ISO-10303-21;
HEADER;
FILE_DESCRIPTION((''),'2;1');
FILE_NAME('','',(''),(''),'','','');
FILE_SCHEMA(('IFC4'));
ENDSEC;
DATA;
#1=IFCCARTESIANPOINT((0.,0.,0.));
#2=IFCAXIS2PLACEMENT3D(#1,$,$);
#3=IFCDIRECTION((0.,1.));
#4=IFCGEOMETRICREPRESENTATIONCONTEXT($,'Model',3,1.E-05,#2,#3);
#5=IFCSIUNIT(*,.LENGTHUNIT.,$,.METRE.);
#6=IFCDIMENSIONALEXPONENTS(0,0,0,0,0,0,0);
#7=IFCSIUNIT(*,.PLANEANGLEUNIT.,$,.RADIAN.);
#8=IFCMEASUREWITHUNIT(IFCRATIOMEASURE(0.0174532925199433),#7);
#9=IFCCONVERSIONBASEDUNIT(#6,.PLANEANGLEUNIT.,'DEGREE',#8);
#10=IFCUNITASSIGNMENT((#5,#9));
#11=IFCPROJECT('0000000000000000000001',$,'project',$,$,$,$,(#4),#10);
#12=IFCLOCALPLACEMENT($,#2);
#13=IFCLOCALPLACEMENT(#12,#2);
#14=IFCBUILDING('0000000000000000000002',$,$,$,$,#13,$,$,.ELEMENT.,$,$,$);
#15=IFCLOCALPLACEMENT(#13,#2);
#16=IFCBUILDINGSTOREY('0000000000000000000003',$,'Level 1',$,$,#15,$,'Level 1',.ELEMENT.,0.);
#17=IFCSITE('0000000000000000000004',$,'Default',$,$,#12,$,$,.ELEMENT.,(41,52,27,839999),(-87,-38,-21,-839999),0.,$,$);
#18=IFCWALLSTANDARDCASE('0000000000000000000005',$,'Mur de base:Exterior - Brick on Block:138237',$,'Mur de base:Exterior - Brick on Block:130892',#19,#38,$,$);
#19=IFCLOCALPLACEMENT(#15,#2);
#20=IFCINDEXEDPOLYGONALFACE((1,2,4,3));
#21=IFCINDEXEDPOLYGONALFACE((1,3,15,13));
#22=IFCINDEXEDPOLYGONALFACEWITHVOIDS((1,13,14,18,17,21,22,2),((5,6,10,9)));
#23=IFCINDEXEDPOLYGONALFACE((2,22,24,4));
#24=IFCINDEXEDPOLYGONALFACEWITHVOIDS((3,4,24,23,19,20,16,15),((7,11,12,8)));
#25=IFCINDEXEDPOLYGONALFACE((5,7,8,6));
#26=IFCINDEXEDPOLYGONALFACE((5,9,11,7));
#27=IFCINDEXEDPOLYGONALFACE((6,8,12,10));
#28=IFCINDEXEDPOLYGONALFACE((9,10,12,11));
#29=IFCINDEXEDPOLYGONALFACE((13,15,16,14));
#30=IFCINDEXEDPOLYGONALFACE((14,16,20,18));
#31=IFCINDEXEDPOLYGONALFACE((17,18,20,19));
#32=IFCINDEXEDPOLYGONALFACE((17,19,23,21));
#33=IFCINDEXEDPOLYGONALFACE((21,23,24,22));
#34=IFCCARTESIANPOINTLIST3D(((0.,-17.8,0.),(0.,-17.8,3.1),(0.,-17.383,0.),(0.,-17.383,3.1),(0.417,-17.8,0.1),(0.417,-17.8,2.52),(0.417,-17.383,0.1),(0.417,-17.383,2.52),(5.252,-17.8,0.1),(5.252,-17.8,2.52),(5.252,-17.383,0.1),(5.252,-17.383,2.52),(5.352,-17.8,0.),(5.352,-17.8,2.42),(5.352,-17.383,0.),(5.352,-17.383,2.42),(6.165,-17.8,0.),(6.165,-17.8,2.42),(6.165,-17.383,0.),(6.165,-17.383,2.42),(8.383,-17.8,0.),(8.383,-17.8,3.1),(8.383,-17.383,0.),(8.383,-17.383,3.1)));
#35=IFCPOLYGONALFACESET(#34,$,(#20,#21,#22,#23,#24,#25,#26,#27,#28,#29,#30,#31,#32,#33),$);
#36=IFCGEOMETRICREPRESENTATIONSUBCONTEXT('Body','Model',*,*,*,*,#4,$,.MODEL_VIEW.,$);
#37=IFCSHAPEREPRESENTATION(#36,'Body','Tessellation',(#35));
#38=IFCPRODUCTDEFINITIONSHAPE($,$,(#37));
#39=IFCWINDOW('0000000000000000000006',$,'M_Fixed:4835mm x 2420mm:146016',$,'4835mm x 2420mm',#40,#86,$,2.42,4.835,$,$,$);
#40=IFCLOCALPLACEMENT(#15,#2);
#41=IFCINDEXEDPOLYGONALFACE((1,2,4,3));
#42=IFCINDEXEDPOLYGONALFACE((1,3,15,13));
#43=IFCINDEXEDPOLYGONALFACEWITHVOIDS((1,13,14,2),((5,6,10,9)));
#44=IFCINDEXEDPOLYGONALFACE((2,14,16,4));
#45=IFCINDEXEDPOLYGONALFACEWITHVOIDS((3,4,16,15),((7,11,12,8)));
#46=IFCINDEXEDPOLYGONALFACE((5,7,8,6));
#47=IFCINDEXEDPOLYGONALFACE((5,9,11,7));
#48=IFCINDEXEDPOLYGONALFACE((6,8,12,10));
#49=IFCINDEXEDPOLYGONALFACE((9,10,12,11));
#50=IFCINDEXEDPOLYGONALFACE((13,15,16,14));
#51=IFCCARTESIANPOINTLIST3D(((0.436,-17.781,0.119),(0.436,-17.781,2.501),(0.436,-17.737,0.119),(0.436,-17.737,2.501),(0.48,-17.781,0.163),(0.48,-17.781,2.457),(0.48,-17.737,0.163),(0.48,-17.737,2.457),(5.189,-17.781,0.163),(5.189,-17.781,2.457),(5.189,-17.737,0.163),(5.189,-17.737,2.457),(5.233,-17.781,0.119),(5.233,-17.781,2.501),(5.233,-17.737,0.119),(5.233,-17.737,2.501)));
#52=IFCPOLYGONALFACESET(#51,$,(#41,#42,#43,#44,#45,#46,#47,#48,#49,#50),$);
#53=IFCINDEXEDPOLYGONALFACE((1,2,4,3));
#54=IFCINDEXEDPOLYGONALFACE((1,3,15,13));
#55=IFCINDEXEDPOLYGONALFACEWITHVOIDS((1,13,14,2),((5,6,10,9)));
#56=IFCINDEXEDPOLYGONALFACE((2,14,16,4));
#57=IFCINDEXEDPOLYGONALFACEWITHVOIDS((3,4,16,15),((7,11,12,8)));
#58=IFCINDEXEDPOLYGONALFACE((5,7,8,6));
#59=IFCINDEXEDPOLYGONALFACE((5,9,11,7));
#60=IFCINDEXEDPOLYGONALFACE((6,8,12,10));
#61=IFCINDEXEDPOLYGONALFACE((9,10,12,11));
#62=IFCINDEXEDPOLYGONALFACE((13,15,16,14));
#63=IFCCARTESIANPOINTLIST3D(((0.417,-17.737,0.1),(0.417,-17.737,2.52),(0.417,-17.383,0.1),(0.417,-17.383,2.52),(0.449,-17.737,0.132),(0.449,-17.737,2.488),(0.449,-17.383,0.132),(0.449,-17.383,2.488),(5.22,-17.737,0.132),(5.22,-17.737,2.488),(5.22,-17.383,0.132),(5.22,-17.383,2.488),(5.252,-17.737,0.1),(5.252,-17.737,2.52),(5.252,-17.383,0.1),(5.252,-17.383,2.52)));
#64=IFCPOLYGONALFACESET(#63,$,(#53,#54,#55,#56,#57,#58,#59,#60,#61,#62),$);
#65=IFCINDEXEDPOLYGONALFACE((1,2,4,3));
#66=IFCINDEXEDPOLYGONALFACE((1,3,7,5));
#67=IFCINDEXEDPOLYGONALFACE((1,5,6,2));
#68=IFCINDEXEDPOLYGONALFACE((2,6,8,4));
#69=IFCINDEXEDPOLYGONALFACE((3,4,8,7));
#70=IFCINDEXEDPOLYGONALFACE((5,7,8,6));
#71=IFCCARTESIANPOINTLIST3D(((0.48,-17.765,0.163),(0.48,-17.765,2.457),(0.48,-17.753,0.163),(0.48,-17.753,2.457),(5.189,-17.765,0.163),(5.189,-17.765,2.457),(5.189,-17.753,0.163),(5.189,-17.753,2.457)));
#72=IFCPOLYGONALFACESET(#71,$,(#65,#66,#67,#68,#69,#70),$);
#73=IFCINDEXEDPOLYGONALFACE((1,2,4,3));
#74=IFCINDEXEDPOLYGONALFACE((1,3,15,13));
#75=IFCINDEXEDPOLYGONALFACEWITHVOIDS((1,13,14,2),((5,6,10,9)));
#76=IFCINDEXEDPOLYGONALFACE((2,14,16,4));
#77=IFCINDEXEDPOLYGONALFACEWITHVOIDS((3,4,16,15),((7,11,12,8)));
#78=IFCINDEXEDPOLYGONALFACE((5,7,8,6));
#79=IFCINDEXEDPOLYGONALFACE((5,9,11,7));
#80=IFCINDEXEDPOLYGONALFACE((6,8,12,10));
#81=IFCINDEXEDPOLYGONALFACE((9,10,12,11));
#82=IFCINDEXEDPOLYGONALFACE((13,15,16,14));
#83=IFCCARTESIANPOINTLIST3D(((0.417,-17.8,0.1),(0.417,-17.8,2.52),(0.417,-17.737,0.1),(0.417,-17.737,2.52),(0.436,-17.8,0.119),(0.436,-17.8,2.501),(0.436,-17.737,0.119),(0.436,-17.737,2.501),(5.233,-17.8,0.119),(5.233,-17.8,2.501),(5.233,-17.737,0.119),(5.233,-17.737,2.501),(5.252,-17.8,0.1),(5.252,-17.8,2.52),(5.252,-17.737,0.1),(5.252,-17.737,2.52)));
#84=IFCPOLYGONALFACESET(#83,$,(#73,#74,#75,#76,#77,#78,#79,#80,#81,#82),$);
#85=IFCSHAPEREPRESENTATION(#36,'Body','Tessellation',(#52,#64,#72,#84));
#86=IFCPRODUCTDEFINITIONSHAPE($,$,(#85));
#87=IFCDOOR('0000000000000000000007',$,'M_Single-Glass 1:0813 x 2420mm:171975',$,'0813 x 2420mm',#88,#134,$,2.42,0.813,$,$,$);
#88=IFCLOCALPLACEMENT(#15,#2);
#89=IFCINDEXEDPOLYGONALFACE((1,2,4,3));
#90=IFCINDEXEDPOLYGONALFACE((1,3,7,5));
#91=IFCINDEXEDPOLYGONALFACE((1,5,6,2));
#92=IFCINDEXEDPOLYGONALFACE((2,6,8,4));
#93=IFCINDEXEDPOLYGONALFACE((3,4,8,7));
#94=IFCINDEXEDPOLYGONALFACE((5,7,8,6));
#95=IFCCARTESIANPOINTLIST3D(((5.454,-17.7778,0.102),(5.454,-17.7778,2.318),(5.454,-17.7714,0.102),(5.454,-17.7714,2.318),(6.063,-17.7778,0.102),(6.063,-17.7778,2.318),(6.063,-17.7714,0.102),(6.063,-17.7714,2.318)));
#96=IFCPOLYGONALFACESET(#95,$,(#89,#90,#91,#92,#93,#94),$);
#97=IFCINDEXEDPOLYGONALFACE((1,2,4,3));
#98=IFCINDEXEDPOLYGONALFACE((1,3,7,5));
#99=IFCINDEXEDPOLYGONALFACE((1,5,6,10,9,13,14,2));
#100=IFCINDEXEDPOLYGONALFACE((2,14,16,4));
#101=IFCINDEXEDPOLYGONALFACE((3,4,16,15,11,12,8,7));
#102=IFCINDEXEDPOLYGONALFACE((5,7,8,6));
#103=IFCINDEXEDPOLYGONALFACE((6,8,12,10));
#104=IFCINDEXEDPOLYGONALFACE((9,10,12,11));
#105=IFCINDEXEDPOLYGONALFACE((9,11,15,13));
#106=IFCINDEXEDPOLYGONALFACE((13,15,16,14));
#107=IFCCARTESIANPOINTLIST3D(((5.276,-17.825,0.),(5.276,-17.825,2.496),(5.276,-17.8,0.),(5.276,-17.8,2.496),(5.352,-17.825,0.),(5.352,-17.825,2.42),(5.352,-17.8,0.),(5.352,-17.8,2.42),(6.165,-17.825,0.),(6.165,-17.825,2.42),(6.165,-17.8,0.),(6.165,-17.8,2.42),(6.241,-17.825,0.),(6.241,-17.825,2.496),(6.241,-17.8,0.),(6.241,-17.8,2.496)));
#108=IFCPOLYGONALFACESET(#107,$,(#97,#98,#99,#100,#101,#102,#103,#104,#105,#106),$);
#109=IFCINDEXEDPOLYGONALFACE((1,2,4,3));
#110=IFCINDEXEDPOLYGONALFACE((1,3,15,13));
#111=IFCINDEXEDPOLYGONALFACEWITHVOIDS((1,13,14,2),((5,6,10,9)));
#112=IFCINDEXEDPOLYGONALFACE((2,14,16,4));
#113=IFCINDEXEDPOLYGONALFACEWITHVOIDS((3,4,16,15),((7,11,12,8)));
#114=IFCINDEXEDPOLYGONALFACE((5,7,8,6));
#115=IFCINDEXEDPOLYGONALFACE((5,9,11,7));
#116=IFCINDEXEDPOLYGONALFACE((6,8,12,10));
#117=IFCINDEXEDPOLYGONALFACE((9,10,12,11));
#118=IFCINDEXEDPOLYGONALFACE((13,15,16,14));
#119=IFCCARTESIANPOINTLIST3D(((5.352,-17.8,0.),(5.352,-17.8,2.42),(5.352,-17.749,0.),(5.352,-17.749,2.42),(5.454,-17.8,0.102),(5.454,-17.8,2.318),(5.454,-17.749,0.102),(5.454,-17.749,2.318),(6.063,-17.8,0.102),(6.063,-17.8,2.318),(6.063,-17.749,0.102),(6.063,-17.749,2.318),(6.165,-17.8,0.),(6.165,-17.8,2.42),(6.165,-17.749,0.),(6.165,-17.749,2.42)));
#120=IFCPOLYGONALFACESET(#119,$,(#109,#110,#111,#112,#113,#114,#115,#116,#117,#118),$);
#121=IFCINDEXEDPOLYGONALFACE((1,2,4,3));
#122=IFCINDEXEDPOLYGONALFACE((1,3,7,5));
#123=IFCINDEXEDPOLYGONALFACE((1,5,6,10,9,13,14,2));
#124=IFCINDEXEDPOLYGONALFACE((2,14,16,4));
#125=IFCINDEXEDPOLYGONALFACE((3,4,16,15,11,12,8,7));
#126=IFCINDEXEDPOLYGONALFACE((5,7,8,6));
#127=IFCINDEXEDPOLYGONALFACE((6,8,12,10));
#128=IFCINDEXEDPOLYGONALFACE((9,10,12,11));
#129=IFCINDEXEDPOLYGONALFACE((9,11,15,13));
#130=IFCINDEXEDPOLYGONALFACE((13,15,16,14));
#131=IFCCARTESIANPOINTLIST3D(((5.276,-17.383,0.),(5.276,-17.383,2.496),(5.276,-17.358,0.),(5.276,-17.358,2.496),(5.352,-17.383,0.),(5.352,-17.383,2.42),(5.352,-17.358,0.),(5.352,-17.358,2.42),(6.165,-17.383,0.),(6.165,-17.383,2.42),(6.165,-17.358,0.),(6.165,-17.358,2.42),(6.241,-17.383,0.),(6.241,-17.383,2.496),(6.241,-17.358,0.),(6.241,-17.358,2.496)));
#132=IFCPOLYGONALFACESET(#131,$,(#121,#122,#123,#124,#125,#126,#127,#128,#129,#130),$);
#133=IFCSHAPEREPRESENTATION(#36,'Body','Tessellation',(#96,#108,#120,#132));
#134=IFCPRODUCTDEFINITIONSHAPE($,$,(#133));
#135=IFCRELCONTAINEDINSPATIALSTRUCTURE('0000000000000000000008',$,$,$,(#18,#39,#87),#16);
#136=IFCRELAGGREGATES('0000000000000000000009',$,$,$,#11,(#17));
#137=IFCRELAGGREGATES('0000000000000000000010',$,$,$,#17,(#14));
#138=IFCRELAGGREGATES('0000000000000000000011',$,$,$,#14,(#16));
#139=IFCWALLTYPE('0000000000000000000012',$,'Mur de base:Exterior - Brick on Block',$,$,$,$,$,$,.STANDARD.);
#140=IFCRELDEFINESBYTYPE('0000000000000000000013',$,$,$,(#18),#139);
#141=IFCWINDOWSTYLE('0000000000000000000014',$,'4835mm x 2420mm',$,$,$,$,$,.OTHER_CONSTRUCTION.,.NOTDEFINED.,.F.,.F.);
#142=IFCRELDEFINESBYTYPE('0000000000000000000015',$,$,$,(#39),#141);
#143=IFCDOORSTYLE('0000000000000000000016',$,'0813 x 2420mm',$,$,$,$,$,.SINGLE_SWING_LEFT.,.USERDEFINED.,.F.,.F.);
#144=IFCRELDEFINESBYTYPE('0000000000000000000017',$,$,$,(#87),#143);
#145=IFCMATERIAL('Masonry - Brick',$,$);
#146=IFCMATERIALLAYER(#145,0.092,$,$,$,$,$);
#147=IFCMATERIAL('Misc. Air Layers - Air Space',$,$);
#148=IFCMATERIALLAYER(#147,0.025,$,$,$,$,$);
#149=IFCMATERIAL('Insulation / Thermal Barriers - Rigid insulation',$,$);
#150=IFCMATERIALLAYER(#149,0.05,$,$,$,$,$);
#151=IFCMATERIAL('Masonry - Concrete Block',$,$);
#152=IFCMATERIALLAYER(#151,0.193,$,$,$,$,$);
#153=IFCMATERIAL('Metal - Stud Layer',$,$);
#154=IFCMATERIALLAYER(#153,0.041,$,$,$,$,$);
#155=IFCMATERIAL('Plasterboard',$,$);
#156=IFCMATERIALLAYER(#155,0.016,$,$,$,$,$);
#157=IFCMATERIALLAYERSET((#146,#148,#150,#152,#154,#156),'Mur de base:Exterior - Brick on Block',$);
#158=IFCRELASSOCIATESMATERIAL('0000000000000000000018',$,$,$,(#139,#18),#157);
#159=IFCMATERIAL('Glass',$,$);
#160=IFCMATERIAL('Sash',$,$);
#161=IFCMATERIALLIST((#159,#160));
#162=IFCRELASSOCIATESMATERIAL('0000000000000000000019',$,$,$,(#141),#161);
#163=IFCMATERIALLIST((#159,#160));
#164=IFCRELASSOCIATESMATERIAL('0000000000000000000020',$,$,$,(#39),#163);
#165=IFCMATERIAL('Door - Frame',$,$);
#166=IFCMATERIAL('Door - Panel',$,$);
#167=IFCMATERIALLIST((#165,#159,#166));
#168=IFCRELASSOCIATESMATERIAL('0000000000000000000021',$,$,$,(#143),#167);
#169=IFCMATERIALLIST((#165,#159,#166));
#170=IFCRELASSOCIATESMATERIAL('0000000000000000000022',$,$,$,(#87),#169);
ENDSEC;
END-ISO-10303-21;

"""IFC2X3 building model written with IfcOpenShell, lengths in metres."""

from ifc_helpers import new_model, entity, si_unit, converted_unit, direction, frame, frame_2d, origin, origin_2d_with_axis, place, context, subcontext, project, spatial, polyline, rectangle, outline, extrude, source, transform, mapped, material, material_list, layer, layer_set, layer_usage, type_object, type_shapes, element, fill, save


model = new_model("IFC2X3")

# Units and contexts
model_context = context("Model", 3, precision=1e-05, world=origin(), true_north=direction((0.0, 1.0)))
body_context = subcontext(model_context, "Body", "Model", "MODEL_VIEW")
ifc_project = project(units=[si_unit("LENGTHUNIT", "METRE"), converted_unit("PLANEANGLEUNIT", "DEGREE", entity("IfcRatioMeasure", 0.0174532925199433), si_unit("PLANEANGLEUNIT", "RADIAN"), dimensions=[0, 0, 0, 0, 0, 0, 0])], contexts=[model_context])

# Site, building, storey
site_placement = place(None, origin())
site = spatial("IfcSite", under=ifc_project, at=site_placement, Name="Default", CompositionType="ELEMENT", RefLatitude=(41, 52, 27, 839999), RefLongitude=(-87, -38, -21, -839999), RefElevation=0.0)
building_placement = place(site_placement, origin())
building = spatial("IfcBuilding", under=site, at=building_placement, CompositionType="ELEMENT")
storey_placement = place(building_placement, origin())
storey = spatial("IfcBuildingStorey", under=building, at=storey_placement, Name="Level 1", LongName="Level 1", CompositionType="ELEMENT", Elevation=0.0)

# Wall, openings, window, door
ifc_material_1 = material(Name="Masonry - Brick")
ifc_layer_1 = layer(ifc_material_1, 0.092)
ifc_material_2 = material(Name="Misc. Air Layers - Air Space")
ifc_layer_2 = layer(ifc_material_2, 0.025)
ifc_material_3 = material(Name="Insulation / Thermal Barriers - Rigid insulation")
ifc_layer_3 = layer(ifc_material_3, 0.05)
ifc_material_4 = material(Name="Masonry - Concrete Block")
ifc_layer_4 = layer(ifc_material_4, 0.193)
ifc_material_5 = material(Name="Metal - Stud Layer")
ifc_layer_5 = layer(ifc_material_5, 0.041)
ifc_material_6 = material(Name="Plasterboard")
ifc_layer_6 = layer(ifc_material_6, 0.016)
ifc_layer_set_1 = layer_set([ifc_layer_1, ifc_layer_2, ifc_layer_3, ifc_layer_4, ifc_layer_5, ifc_layer_6], Name="Mur de base:Exterior - Brick on Block")
ifc_layer_usage_1 = layer_usage(ifc_layer_set_1, "AXIS2", "NEGATIVE", 0.2085)
wall_type_1 = type_object("IfcWallType", Name="Mur de base:Exterior - Brick on Block", PredefinedType="STANDARD", material=ifc_layer_set_1)
wall_1_placement = place(storey_placement, frame((8.383, -17.5915, 0.0), z_axis=(0.0, 0.0, 1.0), x_axis=(-1.0, 0.0, 0.0)))
wall_1 = element("IfcWallStandardCase", 1, at=wall_1_placement, inside=storey, type_object=wall_type_1, material=ifc_layer_usage_1, Name="Mur de base:Exterior - Brick on Block:138237", ObjectType="Mur de base:Exterior - Brick on Block:130892", context=body_context, shape_type="SweptSolid", body=[
    extrude(rectangle(XDim=8.383, YDim=0.417, at=frame_2d((4.1915, 0.0), x_axis=(-1.0, 0.0))), origin(), (0.0, 0.0, 1.0), 3.1),
])
opening_1_placement = place(wall_1_placement, frame((2.218, -0.2085, 0.0)))
opening_1 = element("IfcOpeningElement", 2, at=opening_1_placement, cuts=wall_1, ObjectType="Opening", context=body_context, shape_type="SweptSolid", body=[
    extrude(rectangle(XDim=0.813, YDim=2.42, at=frame_2d((1.21, 0.4065), x_axis=(0.0, -1.0))), frame((0.0, 0.0, 0.0), z_axis=(0.0, 1.0, 0.0), x_axis=(0.0, 0.0, 1.0)), (0.0, 0.0, 1.0), 0.417),
])
opening_2_placement = place(wall_1_placement, frame((3.131, -0.2085, 0.1)))
opening_2 = element("IfcOpeningElement", 3, at=opening_2_placement, cuts=wall_1, ObjectType="Opening", context=body_context, shape_type="SweptSolid", body=[
    extrude(rectangle(XDim=2.42, YDim=4.835, at=frame_2d((1.21, 2.4175), x_axis=(1.0, 0.0))), frame((0.0, 0.0, 0.0), z_axis=(0.0, 1.0, 0.0), x_axis=(0.0, 0.0, 1.0)), (0.0, 0.0, 1.0), 0.417),
])
ifc_material_7 = material(Name="Glass")
ifc_material_8 = material(Name="Sash")
ifc_material_list_1 = material_list([ifc_material_7, ifc_material_8])
ifc_material_list_2 = material_list([ifc_material_7, ifc_material_8])
window_style_1 = type_object("IfcWindowStyle", Name="4835mm x 2420mm", ConstructionType="OTHER_CONSTRUCTION", OperationType="NOTDEFINED", ParameterTakesPrecedence=False, Sizeable=False, material=ifc_material_list_2)
shared_shape_1 = source(origin(), body_context, "Body", "SweptSolid", [
    extrude(outline(polyline([(-2.3985, -1.191), (2.3985, -1.191), (2.3985, 1.191), (-2.3985, 1.191), (-2.3985, -1.191)]), holes=[polyline([(-2.3545, -1.147), (-2.3545, 1.147), (2.3545, 1.147), (2.3545, -1.147), (-2.3545, -1.147)])]), frame((2.4175, 0.354, 1.21), z_axis=(0.0, 1.0, 0.0), x_axis=(1.0, 0.0, 0.0)), (0.0, 0.0, 1.0), 0.044),
    extrude(outline(polyline([(-2.4175, -1.21), (2.4175, -1.21), (2.4175, 1.21), (-2.4175, 1.21), (-2.4175, -1.21)]), holes=[polyline([(-2.3855, -1.178), (-2.3855, 1.178), (2.3855, 1.178), (2.3855, -1.178), (-2.3855, -1.178)])]), frame((2.4175, 0.0, 1.21), z_axis=(0.0, 1.0, 0.0), x_axis=(1.0, 0.0, 0.0)), (0.0, 0.0, 1.0), 0.354),
    extrude(rectangle(XDim=0.012, YDim=4.709, at=origin_2d_with_axis()), frame((2.4175, 0.376, 0.063), z_axis=(0.0, 0.0, 1.0), x_axis=(0.0, -1.0, 0.0)), (0.0, 0.0, 1.0), 2.294),
    extrude(outline(polyline([(-2.4175, -1.21), (2.4175, -1.21), (2.4175, 1.21), (-2.4175, 1.21), (-2.4175, -1.21)]), holes=[polyline([(-2.3985, -1.191), (-2.3985, 1.191), (2.3985, 1.191), (2.3985, -1.191), (-2.3985, -1.191)])]), frame((2.4175, 0.354, 1.21), z_axis=(0.0, 1.0, 0.0), x_axis=(1.0, 0.0, 0.0)), (0.0, 0.0, 1.0), 0.063),
])
type_shapes(window_style_1, [shared_shape_1])
window_1_placement = place(opening_2_placement, origin())
window_1 = element("IfcWindow", 4, at=window_1_placement, inside=storey, type_object=window_style_1, material=ifc_material_list_1, Name="M_Fixed:4835mm x 2420mm:146016", ObjectType="4835mm x 2420mm", OverallHeight=2.42, OverallWidth=4.835, context=body_context, shape_type="MappedRepresentation", body=[
    mapped(shared_shape_1, transform((0.0, 0.0, 0.0), scale=1.0)),
])
fill(opening_2, window_1)
ifc_material_9 = material(Name="Door - Frame")
ifc_material_10 = material(Name="Door - Panel")
ifc_material_list_3 = material_list([ifc_material_9, ifc_material_7, ifc_material_10])
ifc_material_list_4 = material_list([ifc_material_9, ifc_material_7, ifc_material_10])
door_style_1 = type_object("IfcDoorStyle", Name="0813 x 2420mm", ConstructionType="USERDEFINED", OperationType="SINGLE_SWING_LEFT", ParameterTakesPrecedence=False, Sizeable=False, material=ifc_material_list_4)
shared_shape_2 = source(origin(), body_context, "Body", "SweptSolid", [
    extrude(rectangle(XDim=0.609, YDim=0.0064, at=frame_2d((0.0, 0.0), x_axis=(1.0, 0.0))), frame((0.4065, 0.3916, 0.102)), (0.0, 0.0, 1.0), 2.216),
    extrude(outline(polyline([(-0.4065, -1.191), (-0.4065, 1.229), (-0.4825, 1.229), (-0.4825, -1.267), (0.4825, -1.267), (0.4825, 1.229), (0.4065, 1.229), (0.4065, -1.191), (-0.4065, -1.191)])), frame((0.4065, 0.442, 1.229), z_axis=(0.0, 1.0, 0.0), x_axis=(1.0, 0.0, 0.0)), (0.0, 0.0, -1.0), 0.025),
    extrude(outline(polyline([(-1.21, -0.4065), (1.21, -0.4065), (1.21, 0.4065), (-1.21, 0.4065), (-1.21, -0.4065)]), holes=[polyline([(-1.108, 0.3045), (1.108, 0.3045), (1.108, -0.3045), (-1.108, -0.3045), (-1.108, 0.3045)])]), frame((0.4065, 0.417, 1.21), z_axis=(0.0, -1.0, 0.0), x_axis=(0.0, 0.0, -1.0)), (0.0, 0.0, 1.0), 0.051),
    extrude(outline(polyline([(-0.4065, -1.191), (-0.4065, 1.229), (-0.4825, 1.229), (-0.4825, -1.267), (0.4825, -1.267), (0.4825, 1.229), (0.4065, 1.229), (0.4065, -1.191), (-0.4065, -1.191)])), frame((0.4065, 0.0, 1.229), z_axis=(0.0, 1.0, 0.0), x_axis=(1.0, 0.0, 0.0)), (0.0, 0.0, -1.0), 0.025),
])
type_shapes(door_style_1, [shared_shape_2])
door_1_placement = place(opening_1_placement, origin())
door_1 = element("IfcDoor", 5, at=door_1_placement, inside=storey, type_object=door_style_1, material=ifc_material_list_3, Name="M_Single-Glass 1:0813 x 2420mm:171975", ObjectType="0813 x 2420mm", OverallHeight=2.42, OverallWidth=0.813, context=body_context, shape_type="MappedRepresentation", body=[
    mapped(shared_shape_2, transform((0.0, 0.0, 0.0), scale=1.0)),
])
fill(opening_1, door_1)

save(model, "model.ifc")
